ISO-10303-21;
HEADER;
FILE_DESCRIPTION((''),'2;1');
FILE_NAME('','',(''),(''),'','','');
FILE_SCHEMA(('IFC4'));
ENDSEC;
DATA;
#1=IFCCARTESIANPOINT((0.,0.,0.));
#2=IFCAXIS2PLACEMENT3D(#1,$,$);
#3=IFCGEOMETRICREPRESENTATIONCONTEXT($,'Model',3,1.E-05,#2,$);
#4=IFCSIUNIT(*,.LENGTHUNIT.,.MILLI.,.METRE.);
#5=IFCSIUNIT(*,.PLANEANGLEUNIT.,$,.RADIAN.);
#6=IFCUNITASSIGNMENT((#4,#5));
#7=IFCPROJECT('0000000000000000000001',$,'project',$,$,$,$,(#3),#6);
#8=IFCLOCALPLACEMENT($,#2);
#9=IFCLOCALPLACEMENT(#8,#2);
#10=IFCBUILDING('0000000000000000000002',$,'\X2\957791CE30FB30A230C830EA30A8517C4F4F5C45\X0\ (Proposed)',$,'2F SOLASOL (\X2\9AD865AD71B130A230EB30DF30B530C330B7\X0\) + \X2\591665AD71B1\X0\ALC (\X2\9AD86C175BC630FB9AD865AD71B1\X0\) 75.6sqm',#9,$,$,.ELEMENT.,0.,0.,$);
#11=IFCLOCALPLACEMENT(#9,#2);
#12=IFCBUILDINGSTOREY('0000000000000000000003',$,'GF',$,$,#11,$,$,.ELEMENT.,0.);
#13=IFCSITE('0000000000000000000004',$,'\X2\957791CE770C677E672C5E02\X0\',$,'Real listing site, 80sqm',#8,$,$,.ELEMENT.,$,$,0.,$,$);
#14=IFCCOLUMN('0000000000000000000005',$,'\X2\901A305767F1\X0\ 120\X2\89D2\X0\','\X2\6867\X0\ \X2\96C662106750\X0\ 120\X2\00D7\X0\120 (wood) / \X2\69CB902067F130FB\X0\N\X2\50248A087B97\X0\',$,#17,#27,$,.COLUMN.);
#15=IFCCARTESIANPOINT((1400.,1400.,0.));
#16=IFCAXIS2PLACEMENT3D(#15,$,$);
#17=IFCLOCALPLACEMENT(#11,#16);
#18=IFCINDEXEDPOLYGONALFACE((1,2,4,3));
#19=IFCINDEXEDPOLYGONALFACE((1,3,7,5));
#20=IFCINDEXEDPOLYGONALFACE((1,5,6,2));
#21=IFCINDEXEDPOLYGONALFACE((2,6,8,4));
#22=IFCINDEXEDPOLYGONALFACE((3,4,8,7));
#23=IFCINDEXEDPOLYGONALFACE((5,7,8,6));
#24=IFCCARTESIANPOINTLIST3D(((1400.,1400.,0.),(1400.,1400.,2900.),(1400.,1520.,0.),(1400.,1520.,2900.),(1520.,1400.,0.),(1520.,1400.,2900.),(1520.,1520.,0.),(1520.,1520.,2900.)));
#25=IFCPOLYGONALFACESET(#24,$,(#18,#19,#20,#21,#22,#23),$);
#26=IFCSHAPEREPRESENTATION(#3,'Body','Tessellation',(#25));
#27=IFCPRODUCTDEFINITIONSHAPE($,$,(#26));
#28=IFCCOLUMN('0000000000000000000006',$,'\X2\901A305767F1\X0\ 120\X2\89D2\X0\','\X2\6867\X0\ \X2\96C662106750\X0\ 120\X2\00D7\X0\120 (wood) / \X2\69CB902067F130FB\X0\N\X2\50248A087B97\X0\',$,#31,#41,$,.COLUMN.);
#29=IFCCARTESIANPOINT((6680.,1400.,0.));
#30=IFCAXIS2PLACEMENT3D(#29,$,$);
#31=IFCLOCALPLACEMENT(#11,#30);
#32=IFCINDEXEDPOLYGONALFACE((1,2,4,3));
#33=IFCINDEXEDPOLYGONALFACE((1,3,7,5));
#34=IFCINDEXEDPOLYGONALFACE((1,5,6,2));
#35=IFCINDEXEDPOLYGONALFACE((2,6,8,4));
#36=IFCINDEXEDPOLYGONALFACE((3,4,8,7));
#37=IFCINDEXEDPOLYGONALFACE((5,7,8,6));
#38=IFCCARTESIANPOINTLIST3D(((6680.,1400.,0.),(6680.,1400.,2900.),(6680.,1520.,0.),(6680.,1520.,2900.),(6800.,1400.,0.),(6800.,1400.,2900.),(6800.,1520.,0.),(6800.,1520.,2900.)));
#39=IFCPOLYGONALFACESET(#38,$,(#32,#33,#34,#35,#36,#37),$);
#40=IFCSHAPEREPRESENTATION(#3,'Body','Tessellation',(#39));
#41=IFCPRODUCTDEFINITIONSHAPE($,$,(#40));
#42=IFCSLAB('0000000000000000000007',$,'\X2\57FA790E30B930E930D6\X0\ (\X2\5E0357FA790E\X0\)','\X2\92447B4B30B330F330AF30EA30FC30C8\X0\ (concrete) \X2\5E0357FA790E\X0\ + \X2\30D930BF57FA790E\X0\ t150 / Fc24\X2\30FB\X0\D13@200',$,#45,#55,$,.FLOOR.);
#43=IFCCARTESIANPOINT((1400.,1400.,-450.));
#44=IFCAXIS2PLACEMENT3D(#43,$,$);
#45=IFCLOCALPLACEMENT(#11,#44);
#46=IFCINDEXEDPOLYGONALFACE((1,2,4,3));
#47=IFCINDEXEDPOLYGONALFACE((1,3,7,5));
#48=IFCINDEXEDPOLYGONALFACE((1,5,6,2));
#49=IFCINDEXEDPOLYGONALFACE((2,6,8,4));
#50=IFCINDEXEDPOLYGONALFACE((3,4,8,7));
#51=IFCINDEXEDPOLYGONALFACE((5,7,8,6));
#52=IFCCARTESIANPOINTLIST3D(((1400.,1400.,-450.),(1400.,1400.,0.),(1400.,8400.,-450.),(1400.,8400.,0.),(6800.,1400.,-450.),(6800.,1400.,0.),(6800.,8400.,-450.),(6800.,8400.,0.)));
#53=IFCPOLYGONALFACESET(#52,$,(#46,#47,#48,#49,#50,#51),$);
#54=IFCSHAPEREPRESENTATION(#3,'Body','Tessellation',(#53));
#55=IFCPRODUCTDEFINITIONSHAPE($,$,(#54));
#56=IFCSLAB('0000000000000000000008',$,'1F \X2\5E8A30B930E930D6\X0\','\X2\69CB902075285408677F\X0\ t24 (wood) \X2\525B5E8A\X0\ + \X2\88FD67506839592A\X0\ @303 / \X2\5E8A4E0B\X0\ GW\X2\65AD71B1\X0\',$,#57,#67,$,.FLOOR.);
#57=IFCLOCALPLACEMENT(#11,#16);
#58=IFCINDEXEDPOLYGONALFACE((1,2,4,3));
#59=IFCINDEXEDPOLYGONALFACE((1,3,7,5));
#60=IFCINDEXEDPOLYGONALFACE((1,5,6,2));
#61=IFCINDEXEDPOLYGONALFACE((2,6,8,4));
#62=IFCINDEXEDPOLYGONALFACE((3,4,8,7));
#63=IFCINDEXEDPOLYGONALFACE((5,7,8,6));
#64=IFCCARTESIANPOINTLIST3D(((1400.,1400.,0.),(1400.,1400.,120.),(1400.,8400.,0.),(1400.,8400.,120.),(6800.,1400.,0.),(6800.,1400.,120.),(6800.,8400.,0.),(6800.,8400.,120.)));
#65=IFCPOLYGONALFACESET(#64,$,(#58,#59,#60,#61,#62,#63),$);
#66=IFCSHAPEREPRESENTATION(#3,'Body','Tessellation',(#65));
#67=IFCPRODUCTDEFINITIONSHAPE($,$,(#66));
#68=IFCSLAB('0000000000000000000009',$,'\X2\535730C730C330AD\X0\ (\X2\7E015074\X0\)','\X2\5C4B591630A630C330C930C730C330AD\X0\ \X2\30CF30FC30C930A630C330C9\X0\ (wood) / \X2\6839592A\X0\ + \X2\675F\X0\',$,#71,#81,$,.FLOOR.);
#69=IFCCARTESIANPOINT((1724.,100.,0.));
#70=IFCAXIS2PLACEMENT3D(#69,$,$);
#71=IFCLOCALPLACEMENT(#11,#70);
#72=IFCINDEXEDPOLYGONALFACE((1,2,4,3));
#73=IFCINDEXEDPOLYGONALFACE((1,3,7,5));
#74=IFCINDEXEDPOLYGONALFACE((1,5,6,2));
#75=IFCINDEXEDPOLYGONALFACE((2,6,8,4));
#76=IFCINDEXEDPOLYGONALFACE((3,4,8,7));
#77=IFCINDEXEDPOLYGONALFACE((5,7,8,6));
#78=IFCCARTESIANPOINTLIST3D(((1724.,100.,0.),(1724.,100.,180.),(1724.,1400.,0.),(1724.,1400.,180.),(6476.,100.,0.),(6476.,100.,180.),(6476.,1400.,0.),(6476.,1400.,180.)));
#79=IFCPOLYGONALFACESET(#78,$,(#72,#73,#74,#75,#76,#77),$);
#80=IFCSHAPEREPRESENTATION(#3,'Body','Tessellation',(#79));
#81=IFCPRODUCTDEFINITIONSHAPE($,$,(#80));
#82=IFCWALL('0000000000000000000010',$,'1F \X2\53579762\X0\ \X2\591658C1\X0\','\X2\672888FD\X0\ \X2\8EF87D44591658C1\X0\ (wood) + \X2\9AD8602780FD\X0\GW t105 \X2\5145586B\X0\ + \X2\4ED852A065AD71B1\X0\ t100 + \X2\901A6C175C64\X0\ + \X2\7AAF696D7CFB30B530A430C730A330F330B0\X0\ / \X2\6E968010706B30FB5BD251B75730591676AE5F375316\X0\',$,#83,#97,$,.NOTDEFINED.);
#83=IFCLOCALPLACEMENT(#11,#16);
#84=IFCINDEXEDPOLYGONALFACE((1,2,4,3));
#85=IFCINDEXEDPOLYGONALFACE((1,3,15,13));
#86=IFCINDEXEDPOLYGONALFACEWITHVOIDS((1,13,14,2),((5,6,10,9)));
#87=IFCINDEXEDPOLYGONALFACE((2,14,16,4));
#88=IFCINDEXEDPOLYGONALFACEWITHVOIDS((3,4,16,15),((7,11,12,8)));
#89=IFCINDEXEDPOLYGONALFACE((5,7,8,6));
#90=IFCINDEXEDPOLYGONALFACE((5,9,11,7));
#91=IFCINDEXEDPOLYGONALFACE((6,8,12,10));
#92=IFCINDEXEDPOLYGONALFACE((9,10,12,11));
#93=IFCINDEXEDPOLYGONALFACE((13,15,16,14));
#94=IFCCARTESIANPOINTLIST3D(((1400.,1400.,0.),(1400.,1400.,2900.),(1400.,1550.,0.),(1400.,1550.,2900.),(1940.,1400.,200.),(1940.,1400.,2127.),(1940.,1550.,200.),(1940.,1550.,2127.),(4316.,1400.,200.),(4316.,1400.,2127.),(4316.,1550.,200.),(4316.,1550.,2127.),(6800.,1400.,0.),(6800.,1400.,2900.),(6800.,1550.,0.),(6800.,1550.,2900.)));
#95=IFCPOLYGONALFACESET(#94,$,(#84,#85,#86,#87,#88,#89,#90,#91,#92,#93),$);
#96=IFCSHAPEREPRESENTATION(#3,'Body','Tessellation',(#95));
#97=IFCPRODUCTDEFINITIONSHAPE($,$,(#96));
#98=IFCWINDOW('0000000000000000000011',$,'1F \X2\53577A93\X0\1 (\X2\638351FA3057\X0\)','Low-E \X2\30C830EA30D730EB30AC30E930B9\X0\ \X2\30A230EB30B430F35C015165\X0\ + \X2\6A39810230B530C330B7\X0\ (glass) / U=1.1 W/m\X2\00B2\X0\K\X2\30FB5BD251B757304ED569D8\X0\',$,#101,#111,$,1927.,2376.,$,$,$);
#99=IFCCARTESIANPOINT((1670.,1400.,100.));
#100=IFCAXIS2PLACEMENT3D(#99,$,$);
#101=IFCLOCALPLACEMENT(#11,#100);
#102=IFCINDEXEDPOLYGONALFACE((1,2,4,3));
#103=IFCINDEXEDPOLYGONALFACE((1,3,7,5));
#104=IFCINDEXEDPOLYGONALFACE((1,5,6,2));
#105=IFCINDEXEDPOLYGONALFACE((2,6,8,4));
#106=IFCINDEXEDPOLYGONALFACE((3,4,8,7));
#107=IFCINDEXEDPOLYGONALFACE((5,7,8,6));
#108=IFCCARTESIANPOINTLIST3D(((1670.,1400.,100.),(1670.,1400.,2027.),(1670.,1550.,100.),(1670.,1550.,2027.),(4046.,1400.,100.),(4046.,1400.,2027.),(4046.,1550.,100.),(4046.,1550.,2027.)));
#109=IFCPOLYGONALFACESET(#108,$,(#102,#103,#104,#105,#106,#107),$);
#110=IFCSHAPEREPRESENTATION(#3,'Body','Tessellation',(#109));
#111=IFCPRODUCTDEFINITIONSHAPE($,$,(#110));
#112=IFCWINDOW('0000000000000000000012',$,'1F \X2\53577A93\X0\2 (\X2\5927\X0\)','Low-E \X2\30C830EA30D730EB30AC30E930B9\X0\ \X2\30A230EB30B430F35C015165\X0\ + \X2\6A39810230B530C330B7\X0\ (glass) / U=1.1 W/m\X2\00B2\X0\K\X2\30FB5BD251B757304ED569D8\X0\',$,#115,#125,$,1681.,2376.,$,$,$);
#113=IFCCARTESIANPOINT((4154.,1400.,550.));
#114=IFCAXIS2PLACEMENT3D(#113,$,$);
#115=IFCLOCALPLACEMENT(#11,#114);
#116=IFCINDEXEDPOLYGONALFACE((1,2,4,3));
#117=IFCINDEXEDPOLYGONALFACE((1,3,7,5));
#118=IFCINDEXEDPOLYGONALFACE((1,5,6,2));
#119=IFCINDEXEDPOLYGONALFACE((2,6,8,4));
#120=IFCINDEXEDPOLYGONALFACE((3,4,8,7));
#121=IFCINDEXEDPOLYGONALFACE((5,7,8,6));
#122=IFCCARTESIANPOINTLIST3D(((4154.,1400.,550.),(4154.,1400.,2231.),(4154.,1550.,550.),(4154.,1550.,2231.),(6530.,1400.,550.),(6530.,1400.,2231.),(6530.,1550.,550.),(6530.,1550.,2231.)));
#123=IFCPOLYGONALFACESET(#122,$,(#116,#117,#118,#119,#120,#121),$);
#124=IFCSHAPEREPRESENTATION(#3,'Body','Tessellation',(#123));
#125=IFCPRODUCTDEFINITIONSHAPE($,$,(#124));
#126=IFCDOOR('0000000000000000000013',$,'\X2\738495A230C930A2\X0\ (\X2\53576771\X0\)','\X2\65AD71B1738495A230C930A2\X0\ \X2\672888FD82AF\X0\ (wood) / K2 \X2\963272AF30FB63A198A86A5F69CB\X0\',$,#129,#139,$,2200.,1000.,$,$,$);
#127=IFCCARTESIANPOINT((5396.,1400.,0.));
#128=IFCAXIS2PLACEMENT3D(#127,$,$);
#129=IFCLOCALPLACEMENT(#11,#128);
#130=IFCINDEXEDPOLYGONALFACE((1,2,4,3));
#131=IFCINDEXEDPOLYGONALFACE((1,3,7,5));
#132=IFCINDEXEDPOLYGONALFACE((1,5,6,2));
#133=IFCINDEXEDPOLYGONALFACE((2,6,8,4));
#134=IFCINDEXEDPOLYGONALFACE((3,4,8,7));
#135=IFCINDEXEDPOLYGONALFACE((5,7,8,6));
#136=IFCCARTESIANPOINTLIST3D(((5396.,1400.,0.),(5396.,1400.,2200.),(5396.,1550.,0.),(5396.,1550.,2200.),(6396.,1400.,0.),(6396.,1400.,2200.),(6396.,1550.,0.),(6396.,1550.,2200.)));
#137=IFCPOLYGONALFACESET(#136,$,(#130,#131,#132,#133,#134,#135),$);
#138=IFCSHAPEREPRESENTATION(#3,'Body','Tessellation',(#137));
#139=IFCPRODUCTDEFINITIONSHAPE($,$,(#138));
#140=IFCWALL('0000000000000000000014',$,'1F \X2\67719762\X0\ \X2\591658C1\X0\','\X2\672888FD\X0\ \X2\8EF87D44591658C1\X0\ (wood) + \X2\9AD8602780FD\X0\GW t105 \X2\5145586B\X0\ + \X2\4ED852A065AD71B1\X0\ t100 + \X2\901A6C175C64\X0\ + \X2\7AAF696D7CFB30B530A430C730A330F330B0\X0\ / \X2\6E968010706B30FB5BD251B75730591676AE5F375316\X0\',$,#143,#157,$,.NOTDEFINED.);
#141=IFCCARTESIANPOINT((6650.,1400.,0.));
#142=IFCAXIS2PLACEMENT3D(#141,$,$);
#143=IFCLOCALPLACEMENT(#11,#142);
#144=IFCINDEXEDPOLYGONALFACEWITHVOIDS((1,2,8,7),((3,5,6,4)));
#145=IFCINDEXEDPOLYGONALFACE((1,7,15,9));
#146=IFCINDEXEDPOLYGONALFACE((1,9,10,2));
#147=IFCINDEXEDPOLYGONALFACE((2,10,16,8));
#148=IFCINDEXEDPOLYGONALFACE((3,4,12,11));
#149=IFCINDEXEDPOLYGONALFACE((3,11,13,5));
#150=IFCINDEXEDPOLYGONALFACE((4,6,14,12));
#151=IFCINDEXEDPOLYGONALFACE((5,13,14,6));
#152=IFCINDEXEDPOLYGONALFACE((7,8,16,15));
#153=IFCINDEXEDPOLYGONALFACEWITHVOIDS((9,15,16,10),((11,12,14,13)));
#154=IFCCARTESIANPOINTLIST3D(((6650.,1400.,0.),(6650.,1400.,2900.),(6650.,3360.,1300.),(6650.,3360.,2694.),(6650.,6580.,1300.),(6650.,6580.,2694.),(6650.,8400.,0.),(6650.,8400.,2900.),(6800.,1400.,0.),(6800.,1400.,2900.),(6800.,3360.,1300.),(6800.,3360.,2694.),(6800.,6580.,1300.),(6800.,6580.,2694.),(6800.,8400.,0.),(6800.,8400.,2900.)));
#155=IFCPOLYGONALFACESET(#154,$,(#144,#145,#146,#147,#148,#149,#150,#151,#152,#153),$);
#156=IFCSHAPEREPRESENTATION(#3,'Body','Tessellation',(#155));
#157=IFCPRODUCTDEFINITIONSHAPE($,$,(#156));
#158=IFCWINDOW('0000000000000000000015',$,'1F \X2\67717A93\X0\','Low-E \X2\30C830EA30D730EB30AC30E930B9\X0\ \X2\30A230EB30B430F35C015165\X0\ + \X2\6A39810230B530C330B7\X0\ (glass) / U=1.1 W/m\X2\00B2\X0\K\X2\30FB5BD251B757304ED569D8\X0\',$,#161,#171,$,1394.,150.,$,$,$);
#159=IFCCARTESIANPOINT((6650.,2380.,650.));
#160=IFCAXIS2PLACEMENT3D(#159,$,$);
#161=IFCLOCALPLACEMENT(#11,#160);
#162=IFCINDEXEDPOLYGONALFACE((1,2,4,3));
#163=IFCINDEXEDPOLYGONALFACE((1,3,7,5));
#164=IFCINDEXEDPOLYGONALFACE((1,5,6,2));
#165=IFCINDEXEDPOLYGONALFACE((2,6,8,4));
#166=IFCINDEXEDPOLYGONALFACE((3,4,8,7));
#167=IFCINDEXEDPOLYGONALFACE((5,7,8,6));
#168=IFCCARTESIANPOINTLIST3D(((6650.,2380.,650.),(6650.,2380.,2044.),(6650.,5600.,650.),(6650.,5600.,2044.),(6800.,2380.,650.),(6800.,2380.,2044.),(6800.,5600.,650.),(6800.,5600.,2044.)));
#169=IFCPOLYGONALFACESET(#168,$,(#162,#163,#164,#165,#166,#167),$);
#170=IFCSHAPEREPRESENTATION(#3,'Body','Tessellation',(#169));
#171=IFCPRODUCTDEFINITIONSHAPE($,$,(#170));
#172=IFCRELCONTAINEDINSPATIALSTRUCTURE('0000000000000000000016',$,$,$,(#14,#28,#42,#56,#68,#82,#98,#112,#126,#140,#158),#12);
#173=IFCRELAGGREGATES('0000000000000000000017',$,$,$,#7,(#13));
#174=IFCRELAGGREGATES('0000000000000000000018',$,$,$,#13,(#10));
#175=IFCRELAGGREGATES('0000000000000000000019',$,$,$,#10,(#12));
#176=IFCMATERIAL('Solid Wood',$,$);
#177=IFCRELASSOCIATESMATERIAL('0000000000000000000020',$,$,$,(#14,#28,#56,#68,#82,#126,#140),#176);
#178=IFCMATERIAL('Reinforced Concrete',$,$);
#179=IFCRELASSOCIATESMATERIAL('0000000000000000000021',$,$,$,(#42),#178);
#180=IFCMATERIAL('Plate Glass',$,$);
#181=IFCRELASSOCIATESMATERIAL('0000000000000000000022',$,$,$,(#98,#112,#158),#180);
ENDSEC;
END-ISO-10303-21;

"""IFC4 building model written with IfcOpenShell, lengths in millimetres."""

from ifc_helpers import new_model, si_unit, frame, frame_2d, origin, place, context, project, spatial, rectangle, extrude, material, element, fill, save


model = new_model("IFC4")

# Units and contexts
model_context = context("Model", 3, precision=1e-05, world=origin())
ifc_project = project(units=[si_unit("LENGTHUNIT", "METRE", prefix="MILLI"), si_unit("PLANEANGLEUNIT", "RADIAN")], contexts=[model_context])

# Site, building, storey
site_placement = place(None, origin())
site = spatial("IfcSite", under=ifc_project, at=site_placement, Name="長野県松本市", ObjectType="Real listing site, 80sqm", CompositionType="ELEMENT", RefElevation=0.0)
building_placement = place(site_placement, origin())
building = spatial("IfcBuilding", under=site, at=building_placement, Name="長野・アトリエ兼住居 (Proposed)", ObjectType="2F SOLASOL (高断熱アルミサッシ) + 外断熱ALC (高気密・高断熱) 75.6sqm", CompositionType="ELEMENT", ElevationOfRefHeight=0.0, ElevationOfTerrain=0.0)
storey_placement = place(building_placement, origin())
storey = spatial("IfcBuildingStorey", under=building, at=storey_placement, Name="GF", CompositionType="ELEMENT", Elevation=0.0)

# Columns
ifc_material_1 = material(Name="Solid Wood")
column_1_placement = place(storey_placement, frame((1400.0, 1400.0, 0.0)))
element("IfcColumn", 1, at=column_1_placement, inside=storey, material=ifc_material_1, Name="通し柱 120角", Description="桧 集成材 120×120 (wood) / 構造柱・N値計算", PredefinedType="COLUMN", context=model_context, shape_type="SweptSolid", body=[
    extrude(rectangle(XDim=120.0, YDim=120.0, at=frame_2d((60.0, 60.0))), frame((1400.0, 1400.0, 0.0)), (0.0, 0.0, 1.0), 2900.0),
])
column_2_placement = place(storey_placement, frame((6680.0, 1400.0, 0.0)))
element("IfcColumn", 2, at=column_2_placement, inside=storey, material=ifc_material_1, Name="通し柱 120角", Description="桧 集成材 120×120 (wood) / 構造柱・N値計算", PredefinedType="COLUMN", context=model_context, shape_type="SweptSolid", body=[
    extrude(rectangle(XDim=120.0, YDim=120.0, at=frame_2d((60.0, 60.0))), frame((6680.0, 1400.0, 0.0)), (0.0, 0.0, 1.0), 2900.0),
])

# Slabs
ifc_material_2 = material(Name="Reinforced Concrete")
slab_1_placement = place(storey_placement, frame((1400.0, 1400.0, -450.0)))
element("IfcSlab", 3, at=slab_1_placement, inside=storey, material=ifc_material_2, Name="基礎スラブ (布基礎)", Description="鉄筋コンクリート (concrete) 布基礎 + ベタ基礎 t150 / Fc24・D13@200", PredefinedType="FLOOR", context=model_context, shape_type="SweptSolid", body=[
    extrude(rectangle(XDim=5400.0, YDim=7000.0, at=frame_2d((2700.0, 3500.0))), frame((1400.0, 1400.0, -450.0)), (0.0, 0.0, 1.0), 450.0),
])
slab_2_placement = place(storey_placement, frame((1400.0, 1400.0, 0.0)))
element("IfcSlab", 4, at=slab_2_placement, inside=storey, material=ifc_material_1, Name="1F 床スラブ", Description="構造用合板 t24 (wood) 剛床 + 製材根太 @303 / 床下 GW断熱", PredefinedType="FLOOR", context=model_context, shape_type="SweptSolid", body=[
    extrude(rectangle(XDim=5400.0, YDim=7000.0, at=frame_2d((2700.0, 3500.0))), frame((1400.0, 1400.0, 0.0)), (0.0, 0.0, 1.0), 120.0),
])
slab_3_placement = place(storey_placement, frame((1724.0, 100.0, 0.0)))
element("IfcSlab", 5, at=slab_3_placement, inside=storey, material=ifc_material_1, Name="南デッキ (縁側)", Description="屋外ウッドデッキ ハードウッド (wood) / 根太 + 束", PredefinedType="FLOOR", context=model_context, shape_type="SweptSolid", body=[
    extrude(rectangle(XDim=4752.0, YDim=1300.0, at=frame_2d((2376.0, 650.0))), frame((1724.0, 100.0, 0.0)), (0.0, 0.0, 1.0), 180.0),
])

# Wall, openings, windows, door
wall_1_placement = place(storey_placement, frame((1400.0, 1400.0, 0.0)))
wall_1 = element("IfcWall", 6, at=wall_1_placement, inside=storey, material=ifc_material_1, Name="1F 南面 外壁", Description="木製 軸組外壁 (wood) + 高性能GW t105 充填 + 付加断熱 t100 + 通気層 + 窯業系サイディング / 準耐火・寒冷地外皮強化", PredefinedType="NOTDEFINED", context=model_context, shape_type="SweptSolid", body=[
    extrude(rectangle(XDim=5400.0, YDim=150.0, at=frame_2d((2700.0, 75.0))), frame((1400.0, 1400.0, 0.0)), (0.0, 0.0, 1.0), 2900.0),
])
opening_1_placement = place(storey_placement, frame((1670.0, 1400.0, 100.0)))
opening_1 = element("IfcOpeningElement", 7, at=opening_1_placement, cuts=wall_1, PredefinedType="NOTDEFINED", context=model_context, shape_type="SweptSolid", body=[
    extrude(rectangle(XDim=2376.0, YDim=150.0, at=frame_2d((1188.0, 75.0))), frame((1670.0, 1400.0, 100.0)), (0.0, 0.0, 1.0), 1927.0),
])
opening_2_placement = place(storey_placement, frame((4154.0, 1400.0, 550.0)))
opening_2 = element("IfcOpeningElement", 8, at=opening_2_placement, cuts=wall_1, PredefinedType="NOTDEFINED", context=model_context, shape_type="SweptSolid", body=[
    extrude(rectangle(XDim=2376.0, YDim=150.0, at=frame_2d((1188.0, 75.0))), frame((4154.0, 1400.0, 550.0)), (0.0, 0.0, 1.0), 1681.0),
])
opening_3_placement = place(storey_placement, frame((5396.0, 1400.0, 0.0)))
opening_3 = element("IfcOpeningElement", 9, at=opening_3_placement, cuts=wall_1, PredefinedType="NOTDEFINED", context=model_context, shape_type="SweptSolid", body=[
    extrude(rectangle(XDim=1000.0, YDim=150.0, at=frame_2d((500.0, 75.0))), frame((5396.0, 1400.0, 0.0)), (0.0, 0.0, 1.0), 2200.0),
])
ifc_material_3 = material(Name="Plate Glass")
window_1_placement = place(storey_placement, frame((1670.0, 1400.0, 100.0)))
window_1 = element("IfcWindow", 10, at=window_1_placement, inside=storey, material=ifc_material_3, Name="1F 南窓1 (掃出し)", Description="Low-E トリプルガラス アルゴン封入 + 樹脂サッシ (glass) / U=1.1 W/m²K・寒冷地仕様", OverallHeight=1927.0, OverallWidth=2376.0, context=model_context, shape_type="SweptSolid", body=[
    extrude(rectangle(XDim=2376.0, YDim=150.0, at=frame_2d((1188.0, 75.0))), frame((1670.0, 1400.0, 100.0)), (0.0, 0.0, 1.0), 1927.0),
])
fill(opening_1, window_1)
window_2_placement = place(storey_placement, frame((4154.0, 1400.0, 550.0)))
window_2 = element("IfcWindow", 11, at=window_2_placement, inside=storey, material=ifc_material_3, Name="1F 南窓2 (大)", Description="Low-E トリプルガラス アルゴン封入 + 樹脂サッシ (glass) / U=1.1 W/m²K・寒冷地仕様", OverallHeight=1681.0, OverallWidth=2376.0, context=model_context, shape_type="SweptSolid", body=[
    extrude(rectangle(XDim=2376.0, YDim=150.0, at=frame_2d((1188.0, 75.0))), frame((4154.0, 1400.0, 550.0)), (0.0, 0.0, 1.0), 1681.0),
])
fill(opening_2, window_2)
door_placement = place(storey_placement, frame((5396.0, 1400.0, 0.0)))
door = element("IfcDoor", 12, at=door_placement, inside=storey, material=ifc_material_1, Name="玄関ドア (南東)", Description="断熱玄関ドア 木製芯 (wood) / K2 防犯・採風機構", OverallHeight=2200.0, OverallWidth=1000.0, context=model_context, shape_type="SweptSolid", body=[
    extrude(rectangle(XDim=1000.0, YDim=150.0, at=frame_2d((500.0, 75.0))), frame((5396.0, 1400.0, 0.0)), (0.0, 0.0, 1.0), 2200.0),
])
fill(opening_3, door)

# Wall, opening, window
wall_2_placement = place(storey_placement, frame((6650.0, 1400.0, 0.0)))
wall_2 = element("IfcWall", 13, at=wall_2_placement, inside=storey, material=ifc_material_1, Name="1F 東面 外壁", Description="木製 軸組外壁 (wood) + 高性能GW t105 充填 + 付加断熱 t100 + 通気層 + 窯業系サイディング / 準耐火・寒冷地外皮強化", PredefinedType="NOTDEFINED", context=model_context, shape_type="SweptSolid", body=[
    extrude(rectangle(XDim=150.0, YDim=7000.0, at=frame_2d((75.0, 3500.0))), frame((6650.0, 1400.0, 0.0)), (0.0, 0.0, 1.0), 2900.0),
])
opening_4_placement = place(storey_placement, frame((6650.0, 2380.0, 650.0)))
opening_4 = element("IfcOpeningElement", 14, at=opening_4_placement, cuts=wall_2, PredefinedType="NOTDEFINED", context=model_context, shape_type="SweptSolid", body=[
    extrude(rectangle(XDim=150.0, YDim=3220.0, at=frame_2d((75.0, 1610.0))), frame((6650.0, 2380.0, 650.0)), (0.0, 0.0, 1.0), 1394.0),
])
window_3_placement = place(storey_placement, frame((6650.0, 2380.0, 650.0)))
window_3 = element("IfcWindow", 15, at=window_3_placement, inside=storey, material=ifc_material_3, Name="1F 東窓", Description="Low-E トリプルガラス アルゴン封入 + 樹脂サッシ (glass) / U=1.1 W/m²K・寒冷地仕様", OverallHeight=1394.0, OverallWidth=150.0, context=model_context, shape_type="SweptSolid", body=[
    extrude(rectangle(XDim=150.0, YDim=3220.0, at=frame_2d((75.0, 1610.0))), frame((6650.0, 2380.0, 650.0)), (0.0, 0.0, 1.0), 1394.0),
])
fill(opening_4, window_3)

save(model, "model.ifc")
